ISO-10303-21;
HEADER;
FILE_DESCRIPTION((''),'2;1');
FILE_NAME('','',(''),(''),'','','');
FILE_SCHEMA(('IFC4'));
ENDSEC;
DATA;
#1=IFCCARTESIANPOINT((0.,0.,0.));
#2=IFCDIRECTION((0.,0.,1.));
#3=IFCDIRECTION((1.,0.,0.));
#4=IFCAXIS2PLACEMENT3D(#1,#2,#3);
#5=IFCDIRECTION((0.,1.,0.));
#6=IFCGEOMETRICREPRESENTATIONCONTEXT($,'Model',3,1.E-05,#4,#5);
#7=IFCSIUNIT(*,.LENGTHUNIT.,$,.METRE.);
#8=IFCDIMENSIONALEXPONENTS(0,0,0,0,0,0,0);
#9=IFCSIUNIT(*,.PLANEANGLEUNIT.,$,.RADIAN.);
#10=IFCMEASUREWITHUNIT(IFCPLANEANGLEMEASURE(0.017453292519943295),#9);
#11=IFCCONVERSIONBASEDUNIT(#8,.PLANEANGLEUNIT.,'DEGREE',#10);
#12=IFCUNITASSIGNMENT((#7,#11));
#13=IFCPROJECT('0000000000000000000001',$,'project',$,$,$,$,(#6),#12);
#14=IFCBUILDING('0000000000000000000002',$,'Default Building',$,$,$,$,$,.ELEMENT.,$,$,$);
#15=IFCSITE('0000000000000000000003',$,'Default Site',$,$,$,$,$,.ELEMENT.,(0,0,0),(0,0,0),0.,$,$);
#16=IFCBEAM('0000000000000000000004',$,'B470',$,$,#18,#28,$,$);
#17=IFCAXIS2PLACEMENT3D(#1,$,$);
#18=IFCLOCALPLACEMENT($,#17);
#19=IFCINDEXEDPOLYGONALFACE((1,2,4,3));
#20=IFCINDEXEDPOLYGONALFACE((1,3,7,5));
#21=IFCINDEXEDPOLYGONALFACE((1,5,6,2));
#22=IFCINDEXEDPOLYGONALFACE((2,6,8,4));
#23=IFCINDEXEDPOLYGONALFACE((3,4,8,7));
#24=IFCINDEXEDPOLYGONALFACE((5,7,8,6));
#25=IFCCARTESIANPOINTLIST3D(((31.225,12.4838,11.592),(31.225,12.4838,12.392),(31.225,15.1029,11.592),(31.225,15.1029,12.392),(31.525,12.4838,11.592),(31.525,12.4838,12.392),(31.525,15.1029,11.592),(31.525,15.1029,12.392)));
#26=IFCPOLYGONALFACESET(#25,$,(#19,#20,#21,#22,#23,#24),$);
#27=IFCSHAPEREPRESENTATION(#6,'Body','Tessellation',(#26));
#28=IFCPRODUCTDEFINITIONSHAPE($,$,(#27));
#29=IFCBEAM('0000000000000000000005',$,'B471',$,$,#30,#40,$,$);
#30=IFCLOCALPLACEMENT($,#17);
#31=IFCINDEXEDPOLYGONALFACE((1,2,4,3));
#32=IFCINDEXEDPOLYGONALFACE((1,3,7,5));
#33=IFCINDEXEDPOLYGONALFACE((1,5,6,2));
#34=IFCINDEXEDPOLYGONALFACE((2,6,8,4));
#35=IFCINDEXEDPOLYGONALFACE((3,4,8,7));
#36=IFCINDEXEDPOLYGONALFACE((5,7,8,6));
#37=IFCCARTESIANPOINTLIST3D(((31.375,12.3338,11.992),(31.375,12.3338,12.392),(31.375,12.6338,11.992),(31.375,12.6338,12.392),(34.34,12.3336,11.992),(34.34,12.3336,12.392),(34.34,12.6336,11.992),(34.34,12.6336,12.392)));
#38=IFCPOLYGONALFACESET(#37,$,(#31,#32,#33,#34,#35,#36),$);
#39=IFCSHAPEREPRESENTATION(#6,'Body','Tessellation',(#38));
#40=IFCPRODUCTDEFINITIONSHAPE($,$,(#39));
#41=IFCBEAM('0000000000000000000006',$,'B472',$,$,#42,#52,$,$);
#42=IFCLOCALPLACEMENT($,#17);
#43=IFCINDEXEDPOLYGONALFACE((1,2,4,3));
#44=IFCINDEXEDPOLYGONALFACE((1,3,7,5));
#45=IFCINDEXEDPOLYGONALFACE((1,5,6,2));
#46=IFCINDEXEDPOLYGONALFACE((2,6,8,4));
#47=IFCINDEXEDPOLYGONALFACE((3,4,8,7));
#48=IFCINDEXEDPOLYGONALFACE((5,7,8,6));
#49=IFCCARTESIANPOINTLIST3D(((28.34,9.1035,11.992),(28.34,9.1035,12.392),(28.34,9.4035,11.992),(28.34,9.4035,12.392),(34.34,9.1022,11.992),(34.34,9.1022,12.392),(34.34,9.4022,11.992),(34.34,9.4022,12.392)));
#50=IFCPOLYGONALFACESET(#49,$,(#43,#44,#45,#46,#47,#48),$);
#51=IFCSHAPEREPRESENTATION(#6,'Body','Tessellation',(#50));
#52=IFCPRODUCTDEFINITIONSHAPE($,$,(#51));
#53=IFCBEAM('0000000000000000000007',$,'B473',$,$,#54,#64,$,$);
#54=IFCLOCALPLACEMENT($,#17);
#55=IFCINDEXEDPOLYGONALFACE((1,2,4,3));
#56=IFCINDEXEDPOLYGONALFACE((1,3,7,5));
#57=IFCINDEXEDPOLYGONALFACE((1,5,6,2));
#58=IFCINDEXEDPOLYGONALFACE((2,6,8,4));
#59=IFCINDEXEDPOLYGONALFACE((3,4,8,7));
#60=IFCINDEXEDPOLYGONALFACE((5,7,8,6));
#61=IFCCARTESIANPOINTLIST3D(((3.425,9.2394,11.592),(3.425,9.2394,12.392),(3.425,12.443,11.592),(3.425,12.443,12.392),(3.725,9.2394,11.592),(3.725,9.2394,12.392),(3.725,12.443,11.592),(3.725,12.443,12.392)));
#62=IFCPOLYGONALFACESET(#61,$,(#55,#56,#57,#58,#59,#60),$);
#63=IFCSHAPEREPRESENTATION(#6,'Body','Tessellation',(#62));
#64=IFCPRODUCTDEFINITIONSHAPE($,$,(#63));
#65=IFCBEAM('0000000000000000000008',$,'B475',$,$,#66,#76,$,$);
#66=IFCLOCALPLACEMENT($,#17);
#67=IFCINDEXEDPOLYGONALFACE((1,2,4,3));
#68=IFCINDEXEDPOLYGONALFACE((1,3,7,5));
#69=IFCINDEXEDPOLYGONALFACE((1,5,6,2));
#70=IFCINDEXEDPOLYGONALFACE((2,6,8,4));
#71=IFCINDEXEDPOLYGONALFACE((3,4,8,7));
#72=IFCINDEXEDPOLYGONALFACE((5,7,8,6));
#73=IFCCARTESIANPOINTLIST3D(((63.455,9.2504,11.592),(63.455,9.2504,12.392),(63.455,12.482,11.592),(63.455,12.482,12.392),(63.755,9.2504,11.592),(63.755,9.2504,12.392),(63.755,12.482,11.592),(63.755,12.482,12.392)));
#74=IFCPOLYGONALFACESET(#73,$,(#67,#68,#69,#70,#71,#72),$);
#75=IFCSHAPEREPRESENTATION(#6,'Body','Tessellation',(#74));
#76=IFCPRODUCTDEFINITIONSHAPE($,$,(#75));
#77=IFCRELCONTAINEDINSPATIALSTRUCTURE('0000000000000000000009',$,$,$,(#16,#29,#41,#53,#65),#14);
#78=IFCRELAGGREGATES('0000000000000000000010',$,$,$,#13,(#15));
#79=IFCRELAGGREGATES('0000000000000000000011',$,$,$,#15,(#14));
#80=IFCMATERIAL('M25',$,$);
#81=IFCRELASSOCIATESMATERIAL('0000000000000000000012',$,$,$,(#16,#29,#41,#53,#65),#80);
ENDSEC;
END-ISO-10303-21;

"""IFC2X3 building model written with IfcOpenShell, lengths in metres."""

from ifc_helpers import new_model, entity, si_unit, converted_unit, direction, frame, frame_2d, origin_with_axes, place, context, project, spatial, rectangle, extrude, material, element, save


model = new_model("IFC2X3")

# Units and contexts
model_context = context("Model", 3, precision=1e-05, world=origin_with_axes(), true_north=direction((0.0, 1.0, 0.0)))
ifc_project = project(units=[si_unit("LENGTHUNIT", "METRE"), converted_unit("PLANEANGLEUNIT", "DEGREE", entity("IfcPlaneAngleMeasure", 0.017453292519943295), si_unit("PLANEANGLEUNIT", "RADIAN"), dimensions=[0, 0, 0, 0, 0, 0, 0])], contexts=[model_context])

# Site, building
site = spatial("IfcSite", under=ifc_project, Name="Default Site", CompositionType="ELEMENT", RefLatitude=(0, 0, 0), RefLongitude=(0, 0, 0), RefElevation=0.0)
building = spatial("IfcBuilding", under=site, Name="Default Building", CompositionType="ELEMENT")

# Beams
ifc_material = material(Name="M25")
placement = place(None, origin_with_axes())
element("IfcBeam", 1, at=placement, inside=building, material=ifc_material, Name="B470", context=model_context, shape_type="SweptSolid", body=[
    extrude(rectangle(XDim=0.3, YDim=0.8, at=frame_2d((0.0, 0.0), x_axis=(0.0, 1.0, 0.0))), frame((31.375, 15.1029, 11.992), z_axis=(0.0, -1.0, 0.0), x_axis=(0.0, 0.0, -1.0)), (0.0, 0.0, 1.0), 2.6191),
])
element("IfcBeam", 2, at=placement, inside=building, material=ifc_material, Name="B471", context=model_context, shape_type="SweptSolid", body=[
    extrude(rectangle(XDim=0.3, YDim=0.4, at=frame_2d((0.0, 0.0), x_axis=(0.0, 1.0, 0.0))), frame((31.375, 12.4838, 12.192), z_axis=(1.0, -0.000067, 0.0), x_axis=(0.0, 0.0, -1.0)), (0.0, 0.0, 1.0), 2.965),
])
element("IfcBeam", 3, at=placement, inside=building, material=ifc_material, Name="B472", context=model_context, shape_type="SweptSolid", body=[
    extrude(rectangle(XDim=0.3, YDim=0.4, at=frame_2d((0.0, 0.0), x_axis=(0.0, 1.0, 0.0))), frame((28.34, 9.2535, 12.192), z_axis=(1.0, -0.000213, 0.0), x_axis=(0.0, 0.0, -1.0)), (0.0, 0.0, 1.0), 6.0),
])
element("IfcBeam", 4, at=placement, inside=building, material=ifc_material, Name="B473", context=model_context, shape_type="SweptSolid", body=[
    extrude(rectangle(XDim=0.3, YDim=0.8, at=frame_2d((0.0, 0.0), x_axis=(0.0, 1.0, 0.0))), frame((3.575, 12.443, 11.992), z_axis=(0.0, -1.0, 0.0), x_axis=(0.0, 0.0, -1.0)), (0.0, 0.0, 1.0), 3.2036),
])
element("IfcBeam", 5, at=placement, inside=building, material=ifc_material, Name="B475", context=model_context, shape_type="SweptSolid", body=[
    extrude(rectangle(XDim=0.3, YDim=0.8, at=frame_2d((0.0, 0.0), x_axis=(0.0, 1.0, 0.0))), frame((63.605, 12.482, 11.992), z_axis=(0.0, -1.0, 0.0), x_axis=(0.0, 0.0, -1.0)), (0.0, 0.0, 1.0), 3.2316),
])

save(model, "model.ifc")
